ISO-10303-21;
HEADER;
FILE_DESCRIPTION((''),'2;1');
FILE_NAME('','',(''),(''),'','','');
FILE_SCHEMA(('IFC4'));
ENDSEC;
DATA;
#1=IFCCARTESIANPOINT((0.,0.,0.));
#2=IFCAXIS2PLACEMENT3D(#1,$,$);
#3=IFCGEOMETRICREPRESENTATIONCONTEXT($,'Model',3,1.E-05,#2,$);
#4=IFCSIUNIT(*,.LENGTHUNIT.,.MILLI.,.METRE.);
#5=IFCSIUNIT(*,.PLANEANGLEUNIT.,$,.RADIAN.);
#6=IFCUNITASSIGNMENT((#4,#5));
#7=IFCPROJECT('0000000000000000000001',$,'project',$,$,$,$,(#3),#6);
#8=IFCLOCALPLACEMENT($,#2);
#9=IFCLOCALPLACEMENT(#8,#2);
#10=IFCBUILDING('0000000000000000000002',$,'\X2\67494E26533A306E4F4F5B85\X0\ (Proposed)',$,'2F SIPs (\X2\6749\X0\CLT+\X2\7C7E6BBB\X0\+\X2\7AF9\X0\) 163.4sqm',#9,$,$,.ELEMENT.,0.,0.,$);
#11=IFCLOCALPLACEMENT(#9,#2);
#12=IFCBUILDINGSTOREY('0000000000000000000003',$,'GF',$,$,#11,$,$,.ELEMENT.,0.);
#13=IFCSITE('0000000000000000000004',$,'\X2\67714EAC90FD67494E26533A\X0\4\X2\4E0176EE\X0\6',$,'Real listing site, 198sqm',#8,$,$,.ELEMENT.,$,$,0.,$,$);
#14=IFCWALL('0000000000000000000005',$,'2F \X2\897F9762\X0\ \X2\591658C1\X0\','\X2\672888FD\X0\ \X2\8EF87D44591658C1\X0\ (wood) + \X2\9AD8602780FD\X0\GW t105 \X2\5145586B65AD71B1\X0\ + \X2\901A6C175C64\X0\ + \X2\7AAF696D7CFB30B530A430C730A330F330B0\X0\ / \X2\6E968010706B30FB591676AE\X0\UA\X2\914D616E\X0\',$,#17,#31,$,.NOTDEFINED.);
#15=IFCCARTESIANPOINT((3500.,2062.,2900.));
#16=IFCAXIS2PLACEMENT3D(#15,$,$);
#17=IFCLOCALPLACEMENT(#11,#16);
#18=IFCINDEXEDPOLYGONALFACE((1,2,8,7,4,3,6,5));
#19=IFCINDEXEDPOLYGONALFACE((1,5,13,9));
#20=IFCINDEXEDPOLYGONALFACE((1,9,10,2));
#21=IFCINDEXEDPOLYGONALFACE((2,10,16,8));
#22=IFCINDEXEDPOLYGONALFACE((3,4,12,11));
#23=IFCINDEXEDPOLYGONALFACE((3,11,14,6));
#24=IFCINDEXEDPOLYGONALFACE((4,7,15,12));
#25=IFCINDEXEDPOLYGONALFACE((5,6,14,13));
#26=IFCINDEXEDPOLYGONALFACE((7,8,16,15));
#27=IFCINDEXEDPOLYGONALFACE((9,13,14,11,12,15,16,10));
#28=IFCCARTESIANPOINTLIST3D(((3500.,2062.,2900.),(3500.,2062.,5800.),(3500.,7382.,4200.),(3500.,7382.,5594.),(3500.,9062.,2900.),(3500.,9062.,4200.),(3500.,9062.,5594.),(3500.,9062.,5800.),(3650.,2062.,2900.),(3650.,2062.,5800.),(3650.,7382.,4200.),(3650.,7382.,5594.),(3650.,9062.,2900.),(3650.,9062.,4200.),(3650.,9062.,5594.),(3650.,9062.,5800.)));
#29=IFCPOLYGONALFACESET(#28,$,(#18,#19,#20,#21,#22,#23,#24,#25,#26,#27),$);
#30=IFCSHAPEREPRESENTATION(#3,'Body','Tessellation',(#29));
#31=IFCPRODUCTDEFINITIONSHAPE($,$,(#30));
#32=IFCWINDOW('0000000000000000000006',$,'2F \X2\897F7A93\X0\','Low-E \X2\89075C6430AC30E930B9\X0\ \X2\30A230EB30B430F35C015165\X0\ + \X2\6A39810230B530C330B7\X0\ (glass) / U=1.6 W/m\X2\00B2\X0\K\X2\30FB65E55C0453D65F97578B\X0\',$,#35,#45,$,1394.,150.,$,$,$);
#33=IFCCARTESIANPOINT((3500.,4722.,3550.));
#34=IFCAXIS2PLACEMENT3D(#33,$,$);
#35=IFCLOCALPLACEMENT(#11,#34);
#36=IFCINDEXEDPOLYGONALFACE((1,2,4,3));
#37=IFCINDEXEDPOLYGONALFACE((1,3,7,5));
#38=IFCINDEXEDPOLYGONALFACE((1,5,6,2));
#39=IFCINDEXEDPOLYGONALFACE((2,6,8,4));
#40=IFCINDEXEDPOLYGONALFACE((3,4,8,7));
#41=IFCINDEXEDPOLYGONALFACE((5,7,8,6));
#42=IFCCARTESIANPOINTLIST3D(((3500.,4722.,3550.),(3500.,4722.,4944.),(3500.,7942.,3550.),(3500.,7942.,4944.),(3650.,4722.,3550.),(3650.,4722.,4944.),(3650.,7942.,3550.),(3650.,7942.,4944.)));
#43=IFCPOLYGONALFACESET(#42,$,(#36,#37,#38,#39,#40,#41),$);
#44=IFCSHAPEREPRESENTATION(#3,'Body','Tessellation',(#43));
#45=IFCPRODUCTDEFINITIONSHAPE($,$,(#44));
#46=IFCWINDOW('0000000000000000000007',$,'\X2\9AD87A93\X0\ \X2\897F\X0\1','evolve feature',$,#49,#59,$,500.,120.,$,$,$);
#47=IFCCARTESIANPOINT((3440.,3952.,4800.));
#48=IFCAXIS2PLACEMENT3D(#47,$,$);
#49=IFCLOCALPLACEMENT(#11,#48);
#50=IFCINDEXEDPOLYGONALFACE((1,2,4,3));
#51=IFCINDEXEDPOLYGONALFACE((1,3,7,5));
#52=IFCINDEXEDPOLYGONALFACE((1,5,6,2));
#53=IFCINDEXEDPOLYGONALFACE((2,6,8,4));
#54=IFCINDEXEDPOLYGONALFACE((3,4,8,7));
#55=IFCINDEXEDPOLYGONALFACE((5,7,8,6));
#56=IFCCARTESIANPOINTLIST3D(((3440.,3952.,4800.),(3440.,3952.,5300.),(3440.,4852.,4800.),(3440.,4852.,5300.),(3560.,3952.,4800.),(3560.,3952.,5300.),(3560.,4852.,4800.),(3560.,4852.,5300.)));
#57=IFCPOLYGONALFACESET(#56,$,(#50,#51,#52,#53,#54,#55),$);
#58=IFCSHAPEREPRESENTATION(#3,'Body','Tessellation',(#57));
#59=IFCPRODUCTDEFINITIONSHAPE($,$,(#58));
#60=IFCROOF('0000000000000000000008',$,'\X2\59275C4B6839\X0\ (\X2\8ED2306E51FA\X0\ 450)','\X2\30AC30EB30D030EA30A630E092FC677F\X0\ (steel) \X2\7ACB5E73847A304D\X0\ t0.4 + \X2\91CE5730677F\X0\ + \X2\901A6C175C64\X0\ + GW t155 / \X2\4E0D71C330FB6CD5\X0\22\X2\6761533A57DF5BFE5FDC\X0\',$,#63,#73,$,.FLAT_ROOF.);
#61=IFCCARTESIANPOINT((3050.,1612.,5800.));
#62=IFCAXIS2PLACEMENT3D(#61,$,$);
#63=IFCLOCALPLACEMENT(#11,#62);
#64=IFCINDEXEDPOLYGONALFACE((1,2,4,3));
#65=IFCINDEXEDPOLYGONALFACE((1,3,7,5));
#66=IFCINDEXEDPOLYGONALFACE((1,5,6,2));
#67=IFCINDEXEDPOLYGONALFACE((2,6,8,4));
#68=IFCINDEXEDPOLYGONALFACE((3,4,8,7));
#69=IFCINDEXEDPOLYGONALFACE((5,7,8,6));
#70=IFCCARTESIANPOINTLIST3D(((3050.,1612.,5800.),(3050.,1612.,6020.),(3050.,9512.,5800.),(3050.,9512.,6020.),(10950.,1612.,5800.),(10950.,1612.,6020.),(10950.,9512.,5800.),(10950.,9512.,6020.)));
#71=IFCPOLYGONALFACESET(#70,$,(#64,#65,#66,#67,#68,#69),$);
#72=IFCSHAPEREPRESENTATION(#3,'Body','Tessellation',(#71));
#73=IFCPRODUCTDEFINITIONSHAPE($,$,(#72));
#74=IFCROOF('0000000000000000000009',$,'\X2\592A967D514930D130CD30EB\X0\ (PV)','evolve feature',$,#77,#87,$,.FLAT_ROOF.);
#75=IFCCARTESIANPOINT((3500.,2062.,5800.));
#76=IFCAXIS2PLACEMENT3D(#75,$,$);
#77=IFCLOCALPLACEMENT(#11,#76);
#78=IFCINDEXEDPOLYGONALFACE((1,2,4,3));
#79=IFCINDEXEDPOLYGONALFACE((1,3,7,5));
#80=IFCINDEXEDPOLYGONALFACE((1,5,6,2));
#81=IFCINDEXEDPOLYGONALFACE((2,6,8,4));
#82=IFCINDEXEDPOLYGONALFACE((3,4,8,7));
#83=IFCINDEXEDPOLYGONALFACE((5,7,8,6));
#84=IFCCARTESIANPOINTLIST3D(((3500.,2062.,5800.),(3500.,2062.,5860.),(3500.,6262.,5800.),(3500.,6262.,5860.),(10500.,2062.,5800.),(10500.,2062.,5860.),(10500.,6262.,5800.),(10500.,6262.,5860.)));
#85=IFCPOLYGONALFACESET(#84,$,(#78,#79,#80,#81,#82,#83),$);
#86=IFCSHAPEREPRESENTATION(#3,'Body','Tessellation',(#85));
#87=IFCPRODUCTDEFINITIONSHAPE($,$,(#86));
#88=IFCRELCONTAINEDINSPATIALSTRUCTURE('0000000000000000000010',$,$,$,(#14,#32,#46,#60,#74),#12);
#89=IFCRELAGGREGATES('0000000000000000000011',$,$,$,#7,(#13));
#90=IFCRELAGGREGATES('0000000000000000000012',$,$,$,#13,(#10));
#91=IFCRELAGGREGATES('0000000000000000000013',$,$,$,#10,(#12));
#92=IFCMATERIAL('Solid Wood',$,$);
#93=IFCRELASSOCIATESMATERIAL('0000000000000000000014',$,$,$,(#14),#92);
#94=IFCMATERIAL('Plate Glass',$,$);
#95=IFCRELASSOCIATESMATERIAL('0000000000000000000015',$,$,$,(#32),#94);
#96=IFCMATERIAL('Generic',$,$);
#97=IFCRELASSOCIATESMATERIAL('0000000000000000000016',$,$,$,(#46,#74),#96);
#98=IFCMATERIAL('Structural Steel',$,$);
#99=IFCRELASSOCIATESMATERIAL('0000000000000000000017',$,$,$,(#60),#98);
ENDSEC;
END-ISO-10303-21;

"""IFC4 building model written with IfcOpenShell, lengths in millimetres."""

from ifc_helpers import new_model, si_unit, frame, frame_2d, origin, place, context, project, spatial, rectangle, extrude, material, element, fill, save


model = new_model("IFC4")

# Units and contexts
model_context = context("Model", 3, precision=1e-05, world=origin())
ifc_project = project(units=[si_unit("LENGTHUNIT", "METRE", prefix="MILLI"), si_unit("PLANEANGLEUNIT", "RADIAN")], contexts=[model_context])

# Site, building, storey
site_placement = place(None, origin())
site = spatial("IfcSite", under=ifc_project, at=site_placement, Name="東京都杉並区4丁目6", ObjectType="Real listing site, 198sqm", CompositionType="ELEMENT", RefElevation=0.0)
building_placement = place(site_placement, origin())
building = spatial("IfcBuilding", under=site, at=building_placement, Name="杉並区の住宅 (Proposed)", ObjectType="2F SIPs (杉CLT+籾殻+竹) 163.4sqm", CompositionType="ELEMENT", ElevationOfRefHeight=0.0, ElevationOfTerrain=0.0)
storey_placement = place(building_placement, origin())
storey = spatial("IfcBuildingStorey", under=building, at=storey_placement, Name="GF", CompositionType="ELEMENT", Elevation=0.0)

# Shared definitions
ifc_material_1 = material(Name="Solid Wood")
ifc_material_2 = material(Name="Generic")

# Shared definitions
ifc_material_3 = material(Name="Plate Glass")

# Wall, openings, windows
wall_1_placement = place(storey_placement, frame((3500.0, 2062.0, 2900.0)))
wall_1 = element("IfcWall", 1, at=wall_1_placement, inside=storey, material=ifc_material_1, Name="2F 西面 外壁", Description="木製 軸組外壁 (wood) + 高性能GW t105 充填断熱 + 通気層 + 窯業系サイディング / 準耐火・外皮UA配慮", PredefinedType="NOTDEFINED", context=model_context, shape_type="SweptSolid", body=[
    extrude(rectangle(XDim=150.0, YDim=7000.0, at=frame_2d((75.0, 3500.0))), frame((3500.0, 2062.0, 2900.0)), (0.0, 0.0, 1.0), 2900.0),
])
opening_1_placement = place(storey_placement, frame((3500.0, 4722.0, 3550.0)))
opening_1 = element("IfcOpeningElement", 2, at=opening_1_placement, cuts=wall_1, PredefinedType="NOTDEFINED", context=model_context, shape_type="SweptSolid", body=[
    extrude(rectangle(XDim=150.0, YDim=3220.0, at=frame_2d((75.0, 1610.0))), frame((3500.0, 4722.0, 3550.0)), (0.0, 0.0, 1.0), 1394.0),
])
opening_2_placement = place(storey_placement, frame((3440.0, 3952.0, 4800.0)))
opening_2 = element("IfcOpeningElement", 3, at=opening_2_placement, cuts=wall_1, PredefinedType="NOTDEFINED", context=model_context, shape_type="SweptSolid", body=[
    extrude(rectangle(XDim=120.0, YDim=900.0, at=frame_2d((60.0, 450.0))), frame((3440.0, 3952.0, 4800.0)), (0.0, 0.0, 1.0), 500.0),
])
window_1_placement = place(storey_placement, frame((3500.0, 4722.0, 3550.0)))
window_1 = element("IfcWindow", 4, at=window_1_placement, inside=storey, material=ifc_material_3, Name="2F 西窓", Description="Low-E 複層ガラス アルゴン封入 + 樹脂サッシ (glass) / U=1.6 W/m²K・日射取得型", OverallHeight=1394.0, OverallWidth=150.0, context=model_context, shape_type="SweptSolid", body=[
    extrude(rectangle(XDim=150.0, YDim=3220.0, at=frame_2d((75.0, 1610.0))), frame((3500.0, 4722.0, 3550.0)), (0.0, 0.0, 1.0), 1394.0),
])
fill(opening_1, window_1)
window_2_placement = place(storey_placement, frame((3440.0, 3952.0, 4800.0)))
window_2 = element("IfcWindow", 5, at=window_2_placement, inside=storey, material=ifc_material_2, Name="高窓 西1", Description="evolve feature", OverallHeight=500.0, OverallWidth=120.0, context=model_context, shape_type="SweptSolid", body=[
    extrude(rectangle(XDim=120.0, YDim=900.0, at=frame_2d((60.0, 450.0))), frame((3440.0, 3952.0, 4800.0)), (0.0, 0.0, 1.0), 500.0),
])
fill(opening_2, window_2)

# Roofs
ifc_material_4 = material(Name="Structural Steel")
roof_1_placement = place(storey_placement, frame((3050.0, 1612.0, 5800.0)))
element("IfcRoof", 6, at=roof_1_placement, inside=storey, material=ifc_material_4, Name="大屋根 (軒の出 450)", Description="ガルバリウム鋼板 (steel) 立平葺き t0.4 + 野地板 + 通気層 + GW t155 / 不燃・法22条区域対応", PredefinedType="FLAT_ROOF", context=model_context, shape_type="SweptSolid", body=[
    extrude(rectangle(XDim=7900.0, YDim=7900.0, at=frame_2d((3950.0, 3950.0))), frame((3050.0, 1612.0, 5800.0)), (0.0, 0.0, 1.0), 220.0),
])
roof_2_placement = place(storey_placement, frame((3500.0, 2062.0, 5800.0)))
element("IfcRoof", 7, at=roof_2_placement, inside=storey, material=ifc_material_2, Name="太陽光パネル (PV)", Description="evolve feature", PredefinedType="FLAT_ROOF", context=model_context, shape_type="SweptSolid", body=[
    extrude(rectangle(XDim=7000.0, YDim=4200.0, at=frame_2d((3500.0, 2100.0))), frame((3500.0, 2062.0, 5800.0)), (0.0, 0.0, 1.0), 60.0),
])

save(model, "model.ifc")
